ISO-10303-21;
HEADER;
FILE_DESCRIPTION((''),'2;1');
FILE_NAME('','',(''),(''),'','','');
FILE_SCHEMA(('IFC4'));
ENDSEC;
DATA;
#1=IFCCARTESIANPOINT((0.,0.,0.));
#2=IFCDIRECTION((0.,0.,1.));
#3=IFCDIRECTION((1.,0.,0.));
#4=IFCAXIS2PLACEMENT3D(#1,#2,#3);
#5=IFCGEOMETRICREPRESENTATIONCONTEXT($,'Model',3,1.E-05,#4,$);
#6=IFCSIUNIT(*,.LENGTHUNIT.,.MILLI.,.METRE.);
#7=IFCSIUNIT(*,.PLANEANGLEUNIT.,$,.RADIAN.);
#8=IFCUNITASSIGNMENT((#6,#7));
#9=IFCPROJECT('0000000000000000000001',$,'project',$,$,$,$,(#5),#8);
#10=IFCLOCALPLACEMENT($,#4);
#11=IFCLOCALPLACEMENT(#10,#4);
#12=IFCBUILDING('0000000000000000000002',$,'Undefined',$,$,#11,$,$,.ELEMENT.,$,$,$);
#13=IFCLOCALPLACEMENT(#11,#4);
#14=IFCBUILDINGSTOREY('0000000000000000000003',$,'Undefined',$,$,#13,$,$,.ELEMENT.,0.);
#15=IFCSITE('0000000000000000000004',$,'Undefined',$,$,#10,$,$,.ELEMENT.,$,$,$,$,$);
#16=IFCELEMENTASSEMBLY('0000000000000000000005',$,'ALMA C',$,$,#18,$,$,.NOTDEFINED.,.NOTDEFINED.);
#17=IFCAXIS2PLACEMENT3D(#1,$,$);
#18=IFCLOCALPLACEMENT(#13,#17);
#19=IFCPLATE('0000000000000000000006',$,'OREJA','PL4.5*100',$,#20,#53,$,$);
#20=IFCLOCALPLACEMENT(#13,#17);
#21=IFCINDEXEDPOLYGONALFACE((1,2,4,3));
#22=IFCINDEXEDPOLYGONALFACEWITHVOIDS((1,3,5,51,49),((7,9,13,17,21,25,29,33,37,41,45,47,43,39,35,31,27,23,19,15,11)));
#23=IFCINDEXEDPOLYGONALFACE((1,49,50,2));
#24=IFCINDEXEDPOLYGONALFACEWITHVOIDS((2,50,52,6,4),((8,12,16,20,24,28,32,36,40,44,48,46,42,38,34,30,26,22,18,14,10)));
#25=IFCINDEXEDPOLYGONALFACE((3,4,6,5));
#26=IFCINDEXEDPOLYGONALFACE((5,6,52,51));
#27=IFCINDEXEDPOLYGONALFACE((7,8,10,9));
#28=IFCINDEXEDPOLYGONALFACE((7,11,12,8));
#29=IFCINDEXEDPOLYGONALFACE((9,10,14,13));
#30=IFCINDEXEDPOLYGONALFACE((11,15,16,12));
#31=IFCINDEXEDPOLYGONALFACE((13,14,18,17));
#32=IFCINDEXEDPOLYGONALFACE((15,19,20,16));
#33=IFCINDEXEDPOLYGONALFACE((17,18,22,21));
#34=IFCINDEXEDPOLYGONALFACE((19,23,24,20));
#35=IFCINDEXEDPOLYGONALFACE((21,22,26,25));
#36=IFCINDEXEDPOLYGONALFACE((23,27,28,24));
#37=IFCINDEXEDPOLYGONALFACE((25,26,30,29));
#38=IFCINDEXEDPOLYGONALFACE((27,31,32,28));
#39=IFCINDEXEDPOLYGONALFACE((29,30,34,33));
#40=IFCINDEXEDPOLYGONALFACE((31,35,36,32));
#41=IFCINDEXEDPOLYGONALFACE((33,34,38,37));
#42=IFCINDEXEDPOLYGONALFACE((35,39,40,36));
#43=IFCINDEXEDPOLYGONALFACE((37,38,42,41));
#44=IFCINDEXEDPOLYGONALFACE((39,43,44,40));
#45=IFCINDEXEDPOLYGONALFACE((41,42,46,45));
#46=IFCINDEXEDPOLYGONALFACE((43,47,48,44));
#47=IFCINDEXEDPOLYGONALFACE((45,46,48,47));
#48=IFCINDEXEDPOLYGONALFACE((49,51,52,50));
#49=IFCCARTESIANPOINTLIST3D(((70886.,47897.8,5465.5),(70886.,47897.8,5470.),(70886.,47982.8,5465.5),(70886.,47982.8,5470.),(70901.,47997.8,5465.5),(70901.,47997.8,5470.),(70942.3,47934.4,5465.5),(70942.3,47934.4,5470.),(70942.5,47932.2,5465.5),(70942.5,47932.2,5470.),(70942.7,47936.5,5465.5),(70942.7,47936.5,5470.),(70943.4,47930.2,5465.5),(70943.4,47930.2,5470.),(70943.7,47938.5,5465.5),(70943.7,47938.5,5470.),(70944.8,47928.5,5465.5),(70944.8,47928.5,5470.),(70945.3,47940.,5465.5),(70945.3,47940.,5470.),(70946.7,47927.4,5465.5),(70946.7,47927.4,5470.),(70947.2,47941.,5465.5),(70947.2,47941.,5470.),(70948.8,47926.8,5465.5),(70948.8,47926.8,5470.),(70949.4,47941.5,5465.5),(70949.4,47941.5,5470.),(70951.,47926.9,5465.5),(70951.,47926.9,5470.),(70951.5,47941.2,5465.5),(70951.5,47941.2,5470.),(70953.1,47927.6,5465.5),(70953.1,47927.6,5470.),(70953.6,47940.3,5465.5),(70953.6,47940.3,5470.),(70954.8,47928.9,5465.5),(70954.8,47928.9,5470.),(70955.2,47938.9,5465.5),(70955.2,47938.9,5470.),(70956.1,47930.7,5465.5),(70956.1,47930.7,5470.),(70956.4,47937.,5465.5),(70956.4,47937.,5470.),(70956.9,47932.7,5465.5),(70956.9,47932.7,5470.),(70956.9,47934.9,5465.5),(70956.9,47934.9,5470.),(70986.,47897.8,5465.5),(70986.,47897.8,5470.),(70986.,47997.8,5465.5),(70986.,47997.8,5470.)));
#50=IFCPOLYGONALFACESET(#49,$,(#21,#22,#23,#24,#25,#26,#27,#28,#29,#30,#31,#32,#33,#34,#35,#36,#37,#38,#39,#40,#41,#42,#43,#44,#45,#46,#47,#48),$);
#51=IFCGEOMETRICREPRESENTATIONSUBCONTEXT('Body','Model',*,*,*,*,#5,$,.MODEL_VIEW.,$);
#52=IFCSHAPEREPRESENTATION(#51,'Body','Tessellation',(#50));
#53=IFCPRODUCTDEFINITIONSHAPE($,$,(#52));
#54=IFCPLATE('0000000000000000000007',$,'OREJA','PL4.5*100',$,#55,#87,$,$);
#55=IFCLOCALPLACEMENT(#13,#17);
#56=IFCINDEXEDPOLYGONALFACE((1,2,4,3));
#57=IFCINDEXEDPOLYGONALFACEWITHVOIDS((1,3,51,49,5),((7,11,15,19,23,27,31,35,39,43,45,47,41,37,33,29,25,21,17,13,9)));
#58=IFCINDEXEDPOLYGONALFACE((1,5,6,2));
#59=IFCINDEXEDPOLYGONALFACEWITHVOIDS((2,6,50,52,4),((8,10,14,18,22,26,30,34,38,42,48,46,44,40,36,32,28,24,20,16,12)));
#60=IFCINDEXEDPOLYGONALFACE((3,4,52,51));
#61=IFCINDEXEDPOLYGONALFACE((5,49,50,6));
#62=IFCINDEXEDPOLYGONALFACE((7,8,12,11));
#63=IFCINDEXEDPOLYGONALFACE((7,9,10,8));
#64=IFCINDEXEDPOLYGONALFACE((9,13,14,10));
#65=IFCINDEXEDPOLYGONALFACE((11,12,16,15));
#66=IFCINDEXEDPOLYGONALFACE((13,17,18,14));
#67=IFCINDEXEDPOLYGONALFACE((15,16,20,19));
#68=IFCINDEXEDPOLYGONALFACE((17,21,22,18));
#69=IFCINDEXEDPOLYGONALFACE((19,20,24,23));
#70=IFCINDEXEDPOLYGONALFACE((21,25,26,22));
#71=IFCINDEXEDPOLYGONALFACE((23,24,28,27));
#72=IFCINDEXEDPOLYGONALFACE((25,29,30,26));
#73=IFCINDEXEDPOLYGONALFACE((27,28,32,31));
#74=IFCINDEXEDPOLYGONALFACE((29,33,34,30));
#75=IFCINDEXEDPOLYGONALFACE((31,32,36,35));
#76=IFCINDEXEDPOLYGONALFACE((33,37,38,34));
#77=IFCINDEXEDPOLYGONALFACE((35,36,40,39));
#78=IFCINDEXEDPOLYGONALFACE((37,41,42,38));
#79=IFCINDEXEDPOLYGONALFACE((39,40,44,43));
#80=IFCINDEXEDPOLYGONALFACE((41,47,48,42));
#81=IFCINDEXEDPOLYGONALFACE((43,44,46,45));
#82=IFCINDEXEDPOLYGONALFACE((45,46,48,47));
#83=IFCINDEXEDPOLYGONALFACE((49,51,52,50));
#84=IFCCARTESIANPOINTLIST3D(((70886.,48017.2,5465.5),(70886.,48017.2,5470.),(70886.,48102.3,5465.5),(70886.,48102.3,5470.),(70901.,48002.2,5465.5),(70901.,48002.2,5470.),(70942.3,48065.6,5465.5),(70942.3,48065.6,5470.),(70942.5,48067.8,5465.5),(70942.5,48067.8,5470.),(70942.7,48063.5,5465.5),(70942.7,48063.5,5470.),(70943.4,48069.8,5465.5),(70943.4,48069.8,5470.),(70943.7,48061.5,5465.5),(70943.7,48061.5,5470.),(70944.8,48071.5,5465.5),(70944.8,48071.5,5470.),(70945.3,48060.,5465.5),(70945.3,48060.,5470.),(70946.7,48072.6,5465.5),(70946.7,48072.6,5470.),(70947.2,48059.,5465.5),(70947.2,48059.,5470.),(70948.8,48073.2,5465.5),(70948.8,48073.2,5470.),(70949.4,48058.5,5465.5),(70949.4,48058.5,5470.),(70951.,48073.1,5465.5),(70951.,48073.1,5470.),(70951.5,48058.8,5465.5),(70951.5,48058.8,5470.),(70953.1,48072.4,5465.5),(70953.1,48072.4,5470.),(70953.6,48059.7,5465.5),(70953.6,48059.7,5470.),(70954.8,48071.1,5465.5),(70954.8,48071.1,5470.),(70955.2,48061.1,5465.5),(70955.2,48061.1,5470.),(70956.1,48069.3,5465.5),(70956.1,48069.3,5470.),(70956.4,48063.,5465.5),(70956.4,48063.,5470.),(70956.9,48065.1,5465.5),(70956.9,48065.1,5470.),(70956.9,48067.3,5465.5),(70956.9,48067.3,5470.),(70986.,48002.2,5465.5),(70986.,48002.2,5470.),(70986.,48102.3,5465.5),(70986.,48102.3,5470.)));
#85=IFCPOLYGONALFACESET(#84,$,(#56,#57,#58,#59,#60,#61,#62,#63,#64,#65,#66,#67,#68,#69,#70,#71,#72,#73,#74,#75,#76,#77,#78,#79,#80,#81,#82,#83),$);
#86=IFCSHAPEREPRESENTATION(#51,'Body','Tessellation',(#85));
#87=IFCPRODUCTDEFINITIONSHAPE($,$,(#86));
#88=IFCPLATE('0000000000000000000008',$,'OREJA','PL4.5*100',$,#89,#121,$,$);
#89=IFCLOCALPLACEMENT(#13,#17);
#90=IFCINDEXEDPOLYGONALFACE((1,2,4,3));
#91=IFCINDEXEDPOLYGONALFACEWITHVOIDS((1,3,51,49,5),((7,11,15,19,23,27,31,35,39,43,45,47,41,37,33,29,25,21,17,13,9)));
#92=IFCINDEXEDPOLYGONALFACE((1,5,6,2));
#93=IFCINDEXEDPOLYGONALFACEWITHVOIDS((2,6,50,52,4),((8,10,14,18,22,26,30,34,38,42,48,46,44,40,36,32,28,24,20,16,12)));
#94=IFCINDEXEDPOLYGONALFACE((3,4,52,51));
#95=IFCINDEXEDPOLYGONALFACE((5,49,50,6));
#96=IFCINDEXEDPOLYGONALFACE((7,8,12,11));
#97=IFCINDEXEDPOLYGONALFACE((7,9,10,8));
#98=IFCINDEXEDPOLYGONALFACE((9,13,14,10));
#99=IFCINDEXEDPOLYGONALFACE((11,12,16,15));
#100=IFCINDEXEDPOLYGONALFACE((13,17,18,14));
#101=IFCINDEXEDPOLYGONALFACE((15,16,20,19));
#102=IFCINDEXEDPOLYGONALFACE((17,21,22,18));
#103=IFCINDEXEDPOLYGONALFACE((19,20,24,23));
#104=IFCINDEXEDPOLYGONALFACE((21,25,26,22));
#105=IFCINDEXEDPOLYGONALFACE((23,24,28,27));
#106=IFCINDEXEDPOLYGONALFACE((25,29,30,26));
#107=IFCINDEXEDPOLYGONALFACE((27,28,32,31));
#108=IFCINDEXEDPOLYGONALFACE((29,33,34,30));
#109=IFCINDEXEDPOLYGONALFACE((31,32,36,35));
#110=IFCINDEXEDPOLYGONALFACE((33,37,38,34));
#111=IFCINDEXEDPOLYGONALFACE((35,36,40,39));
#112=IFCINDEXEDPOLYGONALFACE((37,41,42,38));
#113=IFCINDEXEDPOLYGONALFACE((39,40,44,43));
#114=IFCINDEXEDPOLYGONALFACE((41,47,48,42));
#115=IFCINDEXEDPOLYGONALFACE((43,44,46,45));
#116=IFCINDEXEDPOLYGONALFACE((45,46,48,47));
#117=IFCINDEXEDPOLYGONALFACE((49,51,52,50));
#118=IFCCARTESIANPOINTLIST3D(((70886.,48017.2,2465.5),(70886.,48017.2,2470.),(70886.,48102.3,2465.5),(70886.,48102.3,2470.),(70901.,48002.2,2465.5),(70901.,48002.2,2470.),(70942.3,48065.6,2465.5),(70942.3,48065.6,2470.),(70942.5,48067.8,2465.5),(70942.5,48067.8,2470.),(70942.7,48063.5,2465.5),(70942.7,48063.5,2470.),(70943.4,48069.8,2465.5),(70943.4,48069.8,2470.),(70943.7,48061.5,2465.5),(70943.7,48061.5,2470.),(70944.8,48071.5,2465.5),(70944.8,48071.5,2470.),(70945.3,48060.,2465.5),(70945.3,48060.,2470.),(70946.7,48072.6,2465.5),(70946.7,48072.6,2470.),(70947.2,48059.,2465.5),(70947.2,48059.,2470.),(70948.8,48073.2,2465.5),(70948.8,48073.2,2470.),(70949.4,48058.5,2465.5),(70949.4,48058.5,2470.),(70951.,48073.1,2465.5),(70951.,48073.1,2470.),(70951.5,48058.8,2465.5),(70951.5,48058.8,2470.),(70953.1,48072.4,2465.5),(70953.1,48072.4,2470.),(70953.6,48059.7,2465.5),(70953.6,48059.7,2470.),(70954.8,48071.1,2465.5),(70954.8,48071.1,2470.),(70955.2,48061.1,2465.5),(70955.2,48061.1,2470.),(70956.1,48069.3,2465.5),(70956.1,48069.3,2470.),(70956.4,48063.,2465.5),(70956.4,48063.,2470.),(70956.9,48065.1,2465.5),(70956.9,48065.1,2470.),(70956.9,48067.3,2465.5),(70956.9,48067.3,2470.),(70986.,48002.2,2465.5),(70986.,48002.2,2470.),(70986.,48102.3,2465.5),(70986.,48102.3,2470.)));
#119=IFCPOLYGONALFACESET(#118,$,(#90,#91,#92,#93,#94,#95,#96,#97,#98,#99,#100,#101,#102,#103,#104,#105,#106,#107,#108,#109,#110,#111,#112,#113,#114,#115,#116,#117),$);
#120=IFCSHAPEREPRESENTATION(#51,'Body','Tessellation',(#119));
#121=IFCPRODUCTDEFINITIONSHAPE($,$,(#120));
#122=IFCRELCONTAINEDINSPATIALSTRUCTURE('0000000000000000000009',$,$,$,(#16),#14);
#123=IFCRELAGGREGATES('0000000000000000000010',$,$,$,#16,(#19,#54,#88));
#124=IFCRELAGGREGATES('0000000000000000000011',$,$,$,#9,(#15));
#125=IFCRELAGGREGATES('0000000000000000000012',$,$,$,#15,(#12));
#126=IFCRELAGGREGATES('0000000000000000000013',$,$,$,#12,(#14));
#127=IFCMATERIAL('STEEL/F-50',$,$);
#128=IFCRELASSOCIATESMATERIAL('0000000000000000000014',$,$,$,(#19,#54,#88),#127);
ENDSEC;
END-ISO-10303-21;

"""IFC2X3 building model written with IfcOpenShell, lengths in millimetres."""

from ifc_helpers import new_model, si_unit, frame, origin_with_axes, origin_2d_with_axis, place, context, subcontext, project, spatial, polyline, circle, outline, extrude, source, transform, mapped, material, element, aggregate, save


model = new_model("IFC2X3")

# Units and contexts
model_context = context("Model", 3, precision=1e-05, world=origin_with_axes())
body_context = subcontext(model_context, "Body", "Model", "MODEL_VIEW")
ifc_project = project(units=[si_unit("LENGTHUNIT", "METRE", prefix="MILLI"), si_unit("PLANEANGLEUNIT", "RADIAN")], contexts=[model_context])

# Site, building, storey
site_placement = place(None, origin_with_axes())
site = spatial("IfcSite", under=ifc_project, at=site_placement, Name="Undefined", CompositionType="ELEMENT")
building_placement = place(site_placement, origin_with_axes())
building = spatial("IfcBuilding", under=site, at=building_placement, Name="Undefined", CompositionType="ELEMENT")
storey_placement = place(building_placement, origin_with_axes())
storey = spatial("IfcBuildingStorey", under=building, at=storey_placement, Name="Undefined", CompositionType="ELEMENT", Elevation=0.0)

# Element assembly
assembly_1_placement = place(storey_placement, origin_with_axes())
assembly_1 = element("IfcElementAssembly", 1, at=assembly_1_placement, inside=storey, Name="ALMA C", AssemblyPlace="NOTDEFINED", PredefinedType="NOTDEFINED")
ifc_material_1 = material(Name="STEEL/F-50")

# Plates, openings
plate_1_placement = place(assembly_1_placement, frame((70886.0, 47997.8, 5467.8), z_axis=(0.0, 0.0, 1.0), x_axis=(0.0, -1.0, 0.0)))
plate_1 = element("IfcPlate", 2, at=plate_1_placement, material=ifc_material_1, Name="OREJA", Description="PL4.5*100", context=body_context, shape_type="SweptSolid", body=[
    extrude(outline(polyline([(0.0, 15.0), (15.0, 0.0), (100.0, 0.0), (100.0, 100.0), (0.0, 100.0), (0.0, 15.0)])), frame((0.0, 0.0, -2.2), z_axis=(0.0, 0.0, 1.0), x_axis=(1.0, 0.0, 0.0)), (0.0, 0.0, 1.0), 4.5),
])
shared_shape_1 = source(origin_with_axes(), body_context, "Body", "SweptSolid", [
    extrude(circle(Radius=7.3, at=origin_2d_with_axis()), frame((0.0, -0.1, 0.0), z_axis=(0.0, 1.0, 0.0), x_axis=(1.0, 0.0, 0.0)), (0.0, 0.0, 1.0), 4.7),
])
opening_1_placement = place(assembly_1_placement, frame((70949.6, 47934.1, 5470.0), z_axis=(0.707107, 0.707107, 0.0), x_axis=(0.707107, -0.707107, 0.0)))
element("IfcOpeningElement", 3, at=opening_1_placement, cuts=plate_1, ObjectType="Opening", context=body_context, shape_type="MappedRepresentation", body=[
    mapped(shared_shape_1, transform((0.0, 0.0, 0.0))),
])
plate_2_placement = place(assembly_1_placement, frame((70886.0, 48002.2, 5467.8), z_axis=(0.0, 0.0, -1.0), x_axis=(0.0, 1.0, 0.0)))
plate_2 = element("IfcPlate", 4, at=plate_2_placement, material=ifc_material_1, Name="OREJA", Description="PL4.5*100", context=body_context, shape_type="SweptSolid", body=[
    extrude(outline(polyline([(0.0, 15.0), (15.0, 0.0), (100.0, 0.0), (100.0, 100.0), (0.0, 100.0), (0.0, 15.0)])), frame((0.0, 0.0, -2.2), z_axis=(0.0, 0.0, 1.0), x_axis=(1.0, 0.0, 0.0)), (0.0, 0.0, 1.0), 4.5),
])
opening_2_placement = place(assembly_1_placement, frame((70949.6, 48065.9, 5470.0), z_axis=(-0.707107, 0.707107, 0.0), x_axis=(0.707107, 0.707107, 0.0)))
element("IfcOpeningElement", 5, at=opening_2_placement, cuts=plate_2, ObjectType="Opening", context=body_context, shape_type="MappedRepresentation", body=[
    mapped(shared_shape_1, transform((0.0, 0.0, 0.0))),
])
plate_3_placement = place(assembly_1_placement, frame((70886.0, 48002.2, 2467.8), z_axis=(0.0, 0.0, -1.0), x_axis=(0.0, 1.0, 0.0)))
plate_3 = element("IfcPlate", 6, at=plate_3_placement, material=ifc_material_1, Name="OREJA", Description="PL4.5*100", context=body_context, shape_type="SweptSolid", body=[
    extrude(outline(polyline([(0.0, 15.0), (15.0, 0.0), (100.0, 0.0), (100.0, 100.0), (0.0, 100.0), (0.0, 15.0)])), frame((0.0, 0.0, -2.2), z_axis=(0.0, 0.0, 1.0), x_axis=(1.0, 0.0, 0.0)), (0.0, 0.0, 1.0), 4.5),
])
opening_3_placement = place(assembly_1_placement, frame((70949.6, 48065.9, 2470.0), z_axis=(-0.707107, 0.707107, 0.0), x_axis=(0.707107, 0.707107, 0.0)))
element("IfcOpeningElement", 7, at=opening_3_placement, cuts=plate_3, ObjectType="Opening", context=body_context, shape_type="MappedRepresentation", body=[
    mapped(shared_shape_1, transform((0.0, 0.0, 0.0))),
])

aggregate(assembly_1, [plate_1, plate_2, plate_3])

save(model, "model.ifc")
